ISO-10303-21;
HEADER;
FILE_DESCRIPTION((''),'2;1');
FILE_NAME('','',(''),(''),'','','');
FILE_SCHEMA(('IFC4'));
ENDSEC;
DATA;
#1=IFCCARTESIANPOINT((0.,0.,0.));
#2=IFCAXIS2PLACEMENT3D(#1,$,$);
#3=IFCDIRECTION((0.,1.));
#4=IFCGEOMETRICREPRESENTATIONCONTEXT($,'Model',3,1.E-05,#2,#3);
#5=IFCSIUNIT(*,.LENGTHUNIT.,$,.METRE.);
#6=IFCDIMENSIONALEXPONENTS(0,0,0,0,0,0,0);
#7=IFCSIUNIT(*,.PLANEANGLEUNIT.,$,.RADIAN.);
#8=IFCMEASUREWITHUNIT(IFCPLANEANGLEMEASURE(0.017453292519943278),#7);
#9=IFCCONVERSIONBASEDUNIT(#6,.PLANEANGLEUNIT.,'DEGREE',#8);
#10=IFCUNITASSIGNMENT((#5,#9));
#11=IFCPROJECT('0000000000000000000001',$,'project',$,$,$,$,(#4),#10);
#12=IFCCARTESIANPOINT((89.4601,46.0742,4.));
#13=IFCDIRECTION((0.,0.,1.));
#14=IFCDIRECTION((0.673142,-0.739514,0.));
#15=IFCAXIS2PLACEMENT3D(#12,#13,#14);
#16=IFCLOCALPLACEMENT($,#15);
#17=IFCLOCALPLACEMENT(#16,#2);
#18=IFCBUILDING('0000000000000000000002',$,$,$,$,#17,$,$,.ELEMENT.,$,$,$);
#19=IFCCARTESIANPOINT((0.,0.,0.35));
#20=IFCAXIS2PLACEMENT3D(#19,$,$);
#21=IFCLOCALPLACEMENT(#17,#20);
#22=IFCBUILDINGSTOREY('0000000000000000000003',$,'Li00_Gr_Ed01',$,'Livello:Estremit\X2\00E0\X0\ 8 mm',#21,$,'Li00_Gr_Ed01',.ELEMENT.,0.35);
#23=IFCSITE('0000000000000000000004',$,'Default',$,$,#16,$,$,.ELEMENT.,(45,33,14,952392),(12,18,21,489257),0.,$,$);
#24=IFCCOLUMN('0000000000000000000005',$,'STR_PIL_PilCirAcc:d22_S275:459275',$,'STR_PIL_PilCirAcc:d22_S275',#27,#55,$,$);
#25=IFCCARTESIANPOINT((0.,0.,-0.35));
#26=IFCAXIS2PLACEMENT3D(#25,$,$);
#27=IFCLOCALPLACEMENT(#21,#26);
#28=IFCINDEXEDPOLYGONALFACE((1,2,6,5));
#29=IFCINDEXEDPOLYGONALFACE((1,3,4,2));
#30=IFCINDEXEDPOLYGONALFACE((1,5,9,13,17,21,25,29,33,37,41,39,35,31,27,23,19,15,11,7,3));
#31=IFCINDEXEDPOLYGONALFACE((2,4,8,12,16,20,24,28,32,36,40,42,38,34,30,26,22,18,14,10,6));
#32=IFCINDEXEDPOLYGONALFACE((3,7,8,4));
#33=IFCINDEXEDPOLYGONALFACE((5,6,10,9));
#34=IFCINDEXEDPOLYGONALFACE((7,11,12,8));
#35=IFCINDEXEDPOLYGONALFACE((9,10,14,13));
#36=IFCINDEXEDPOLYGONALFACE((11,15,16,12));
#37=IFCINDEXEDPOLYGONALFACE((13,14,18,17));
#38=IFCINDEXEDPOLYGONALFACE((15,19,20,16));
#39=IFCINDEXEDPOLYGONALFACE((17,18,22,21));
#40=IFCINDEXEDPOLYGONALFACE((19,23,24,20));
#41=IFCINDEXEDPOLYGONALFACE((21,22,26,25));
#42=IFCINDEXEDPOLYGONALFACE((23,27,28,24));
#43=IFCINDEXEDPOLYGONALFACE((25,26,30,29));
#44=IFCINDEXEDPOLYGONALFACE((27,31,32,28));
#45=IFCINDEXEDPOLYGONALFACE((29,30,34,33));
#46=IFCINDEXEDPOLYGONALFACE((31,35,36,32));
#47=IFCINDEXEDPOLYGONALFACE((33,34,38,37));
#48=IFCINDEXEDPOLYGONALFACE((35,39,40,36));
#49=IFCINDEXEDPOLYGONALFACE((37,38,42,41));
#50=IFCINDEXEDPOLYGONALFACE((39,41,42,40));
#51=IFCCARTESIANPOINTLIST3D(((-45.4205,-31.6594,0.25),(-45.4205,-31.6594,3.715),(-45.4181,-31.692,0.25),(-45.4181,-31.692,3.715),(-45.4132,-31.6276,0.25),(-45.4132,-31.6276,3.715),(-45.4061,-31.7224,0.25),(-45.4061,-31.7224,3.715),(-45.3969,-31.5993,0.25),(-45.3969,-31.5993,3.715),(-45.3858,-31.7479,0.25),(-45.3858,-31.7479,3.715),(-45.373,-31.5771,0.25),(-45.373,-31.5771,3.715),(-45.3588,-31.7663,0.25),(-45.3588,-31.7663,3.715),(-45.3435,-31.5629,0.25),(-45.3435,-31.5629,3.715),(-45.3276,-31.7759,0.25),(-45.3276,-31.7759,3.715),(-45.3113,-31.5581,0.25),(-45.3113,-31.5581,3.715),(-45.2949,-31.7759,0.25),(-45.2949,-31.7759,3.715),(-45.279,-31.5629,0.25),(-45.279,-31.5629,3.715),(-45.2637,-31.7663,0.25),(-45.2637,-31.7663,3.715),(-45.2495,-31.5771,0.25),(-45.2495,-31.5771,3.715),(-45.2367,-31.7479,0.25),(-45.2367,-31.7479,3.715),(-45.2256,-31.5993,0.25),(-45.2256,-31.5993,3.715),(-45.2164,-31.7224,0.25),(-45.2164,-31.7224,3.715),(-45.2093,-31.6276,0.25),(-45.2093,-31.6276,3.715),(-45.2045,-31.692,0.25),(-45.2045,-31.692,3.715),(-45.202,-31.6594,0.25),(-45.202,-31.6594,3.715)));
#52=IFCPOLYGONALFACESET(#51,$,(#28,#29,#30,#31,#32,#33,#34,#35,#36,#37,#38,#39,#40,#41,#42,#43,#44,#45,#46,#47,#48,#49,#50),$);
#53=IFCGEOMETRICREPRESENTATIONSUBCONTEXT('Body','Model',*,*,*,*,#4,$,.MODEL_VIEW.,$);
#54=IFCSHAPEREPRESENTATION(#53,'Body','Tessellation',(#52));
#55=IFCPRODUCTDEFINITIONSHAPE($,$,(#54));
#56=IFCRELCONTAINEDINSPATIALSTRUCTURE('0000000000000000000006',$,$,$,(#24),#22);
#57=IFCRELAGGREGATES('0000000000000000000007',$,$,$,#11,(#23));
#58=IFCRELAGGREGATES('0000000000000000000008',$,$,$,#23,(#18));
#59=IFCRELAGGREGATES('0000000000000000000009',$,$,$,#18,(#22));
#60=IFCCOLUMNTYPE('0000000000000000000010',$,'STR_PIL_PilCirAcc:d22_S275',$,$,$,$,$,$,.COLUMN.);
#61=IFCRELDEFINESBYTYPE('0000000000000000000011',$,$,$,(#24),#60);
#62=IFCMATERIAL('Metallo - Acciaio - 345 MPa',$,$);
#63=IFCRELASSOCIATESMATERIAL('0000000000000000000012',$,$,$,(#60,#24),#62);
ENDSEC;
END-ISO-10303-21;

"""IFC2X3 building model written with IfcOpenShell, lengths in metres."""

from ifc_helpers import new_model, entity, si_unit, converted_unit, direction, frame, origin, origin_2d_with_axis, place, context, subcontext, project, spatial, circle, extrude, source, transform, mapped, material, type_object, type_shapes, element, save


model = new_model("IFC2X3")

# Units and contexts
model_context = context("Model", 3, precision=1e-05, world=origin(), true_north=direction((0.0, 1.0)))
body_context = subcontext(model_context, "Body", "Model", "MODEL_VIEW")
ifc_project = project(units=[si_unit("LENGTHUNIT", "METRE"), converted_unit("PLANEANGLEUNIT", "DEGREE", entity("IfcPlaneAngleMeasure", 0.017453292519943278), si_unit("PLANEANGLEUNIT", "RADIAN"), dimensions=[0, 0, 0, 0, 0, 0, 0])], contexts=[model_context])

# Site, building, storey
site_placement = place(None, frame((89.4601, 46.0742, 4.0), z_axis=(0.0, 0.0, 1.0), x_axis=(0.673142, -0.739514, 0.0)))
site = spatial("IfcSite", under=ifc_project, at=site_placement, Name="Default", CompositionType="ELEMENT", RefLatitude=(45, 33, 14, 952392), RefLongitude=(12, 18, 21, 489257), RefElevation=0.0)
building_placement = place(site_placement, origin())
building = spatial("IfcBuilding", under=site, at=building_placement, CompositionType="ELEMENT")
storey_placement = place(building_placement, frame((0.0, 0.0, 0.35)))
storey = spatial("IfcBuildingStorey", under=building, at=storey_placement, Name="Li00_Gr_Ed01", ObjectType="Livello:Estremità 8 mm", LongName="Li00_Gr_Ed01", CompositionType="ELEMENT", Elevation=0.35)

# Column
ifc_material_1 = material(Name="Metallo - Acciaio - 345 MPa")
column_type_1 = type_object("IfcColumnType", Name="STR_PIL_PilCirAcc:d22_S275", PredefinedType="COLUMN", material=ifc_material_1)
shared_shape_1 = source(origin(), body_context, "Body", "SweptSolid", [
    extrude(circle(Radius=0.1096, at=origin_2d_with_axis()), frame((-45.3113, -31.6676, 0.25), z_axis=(0.0, 0.0, 1.0), x_axis=(0.0, 1.0, 0.0)), (0.0, 0.0, 1.0), 3.465),
])
type_shapes(column_type_1, [shared_shape_1])
column_1_placement = place(storey_placement, frame((0.0, 0.0, -0.35)))
element("IfcColumn", 1, at=column_1_placement, inside=storey, type_object=column_type_1, material=ifc_material_1, Name="STR_PIL_PilCirAcc:d22_S275:459275", ObjectType="STR_PIL_PilCirAcc:d22_S275", context=body_context, shape_type="MappedRepresentation", body=[
    mapped(shared_shape_1, transform((0.0, 0.0, 0.0), scale=1.0)),
])

save(model, "model.ifc")
